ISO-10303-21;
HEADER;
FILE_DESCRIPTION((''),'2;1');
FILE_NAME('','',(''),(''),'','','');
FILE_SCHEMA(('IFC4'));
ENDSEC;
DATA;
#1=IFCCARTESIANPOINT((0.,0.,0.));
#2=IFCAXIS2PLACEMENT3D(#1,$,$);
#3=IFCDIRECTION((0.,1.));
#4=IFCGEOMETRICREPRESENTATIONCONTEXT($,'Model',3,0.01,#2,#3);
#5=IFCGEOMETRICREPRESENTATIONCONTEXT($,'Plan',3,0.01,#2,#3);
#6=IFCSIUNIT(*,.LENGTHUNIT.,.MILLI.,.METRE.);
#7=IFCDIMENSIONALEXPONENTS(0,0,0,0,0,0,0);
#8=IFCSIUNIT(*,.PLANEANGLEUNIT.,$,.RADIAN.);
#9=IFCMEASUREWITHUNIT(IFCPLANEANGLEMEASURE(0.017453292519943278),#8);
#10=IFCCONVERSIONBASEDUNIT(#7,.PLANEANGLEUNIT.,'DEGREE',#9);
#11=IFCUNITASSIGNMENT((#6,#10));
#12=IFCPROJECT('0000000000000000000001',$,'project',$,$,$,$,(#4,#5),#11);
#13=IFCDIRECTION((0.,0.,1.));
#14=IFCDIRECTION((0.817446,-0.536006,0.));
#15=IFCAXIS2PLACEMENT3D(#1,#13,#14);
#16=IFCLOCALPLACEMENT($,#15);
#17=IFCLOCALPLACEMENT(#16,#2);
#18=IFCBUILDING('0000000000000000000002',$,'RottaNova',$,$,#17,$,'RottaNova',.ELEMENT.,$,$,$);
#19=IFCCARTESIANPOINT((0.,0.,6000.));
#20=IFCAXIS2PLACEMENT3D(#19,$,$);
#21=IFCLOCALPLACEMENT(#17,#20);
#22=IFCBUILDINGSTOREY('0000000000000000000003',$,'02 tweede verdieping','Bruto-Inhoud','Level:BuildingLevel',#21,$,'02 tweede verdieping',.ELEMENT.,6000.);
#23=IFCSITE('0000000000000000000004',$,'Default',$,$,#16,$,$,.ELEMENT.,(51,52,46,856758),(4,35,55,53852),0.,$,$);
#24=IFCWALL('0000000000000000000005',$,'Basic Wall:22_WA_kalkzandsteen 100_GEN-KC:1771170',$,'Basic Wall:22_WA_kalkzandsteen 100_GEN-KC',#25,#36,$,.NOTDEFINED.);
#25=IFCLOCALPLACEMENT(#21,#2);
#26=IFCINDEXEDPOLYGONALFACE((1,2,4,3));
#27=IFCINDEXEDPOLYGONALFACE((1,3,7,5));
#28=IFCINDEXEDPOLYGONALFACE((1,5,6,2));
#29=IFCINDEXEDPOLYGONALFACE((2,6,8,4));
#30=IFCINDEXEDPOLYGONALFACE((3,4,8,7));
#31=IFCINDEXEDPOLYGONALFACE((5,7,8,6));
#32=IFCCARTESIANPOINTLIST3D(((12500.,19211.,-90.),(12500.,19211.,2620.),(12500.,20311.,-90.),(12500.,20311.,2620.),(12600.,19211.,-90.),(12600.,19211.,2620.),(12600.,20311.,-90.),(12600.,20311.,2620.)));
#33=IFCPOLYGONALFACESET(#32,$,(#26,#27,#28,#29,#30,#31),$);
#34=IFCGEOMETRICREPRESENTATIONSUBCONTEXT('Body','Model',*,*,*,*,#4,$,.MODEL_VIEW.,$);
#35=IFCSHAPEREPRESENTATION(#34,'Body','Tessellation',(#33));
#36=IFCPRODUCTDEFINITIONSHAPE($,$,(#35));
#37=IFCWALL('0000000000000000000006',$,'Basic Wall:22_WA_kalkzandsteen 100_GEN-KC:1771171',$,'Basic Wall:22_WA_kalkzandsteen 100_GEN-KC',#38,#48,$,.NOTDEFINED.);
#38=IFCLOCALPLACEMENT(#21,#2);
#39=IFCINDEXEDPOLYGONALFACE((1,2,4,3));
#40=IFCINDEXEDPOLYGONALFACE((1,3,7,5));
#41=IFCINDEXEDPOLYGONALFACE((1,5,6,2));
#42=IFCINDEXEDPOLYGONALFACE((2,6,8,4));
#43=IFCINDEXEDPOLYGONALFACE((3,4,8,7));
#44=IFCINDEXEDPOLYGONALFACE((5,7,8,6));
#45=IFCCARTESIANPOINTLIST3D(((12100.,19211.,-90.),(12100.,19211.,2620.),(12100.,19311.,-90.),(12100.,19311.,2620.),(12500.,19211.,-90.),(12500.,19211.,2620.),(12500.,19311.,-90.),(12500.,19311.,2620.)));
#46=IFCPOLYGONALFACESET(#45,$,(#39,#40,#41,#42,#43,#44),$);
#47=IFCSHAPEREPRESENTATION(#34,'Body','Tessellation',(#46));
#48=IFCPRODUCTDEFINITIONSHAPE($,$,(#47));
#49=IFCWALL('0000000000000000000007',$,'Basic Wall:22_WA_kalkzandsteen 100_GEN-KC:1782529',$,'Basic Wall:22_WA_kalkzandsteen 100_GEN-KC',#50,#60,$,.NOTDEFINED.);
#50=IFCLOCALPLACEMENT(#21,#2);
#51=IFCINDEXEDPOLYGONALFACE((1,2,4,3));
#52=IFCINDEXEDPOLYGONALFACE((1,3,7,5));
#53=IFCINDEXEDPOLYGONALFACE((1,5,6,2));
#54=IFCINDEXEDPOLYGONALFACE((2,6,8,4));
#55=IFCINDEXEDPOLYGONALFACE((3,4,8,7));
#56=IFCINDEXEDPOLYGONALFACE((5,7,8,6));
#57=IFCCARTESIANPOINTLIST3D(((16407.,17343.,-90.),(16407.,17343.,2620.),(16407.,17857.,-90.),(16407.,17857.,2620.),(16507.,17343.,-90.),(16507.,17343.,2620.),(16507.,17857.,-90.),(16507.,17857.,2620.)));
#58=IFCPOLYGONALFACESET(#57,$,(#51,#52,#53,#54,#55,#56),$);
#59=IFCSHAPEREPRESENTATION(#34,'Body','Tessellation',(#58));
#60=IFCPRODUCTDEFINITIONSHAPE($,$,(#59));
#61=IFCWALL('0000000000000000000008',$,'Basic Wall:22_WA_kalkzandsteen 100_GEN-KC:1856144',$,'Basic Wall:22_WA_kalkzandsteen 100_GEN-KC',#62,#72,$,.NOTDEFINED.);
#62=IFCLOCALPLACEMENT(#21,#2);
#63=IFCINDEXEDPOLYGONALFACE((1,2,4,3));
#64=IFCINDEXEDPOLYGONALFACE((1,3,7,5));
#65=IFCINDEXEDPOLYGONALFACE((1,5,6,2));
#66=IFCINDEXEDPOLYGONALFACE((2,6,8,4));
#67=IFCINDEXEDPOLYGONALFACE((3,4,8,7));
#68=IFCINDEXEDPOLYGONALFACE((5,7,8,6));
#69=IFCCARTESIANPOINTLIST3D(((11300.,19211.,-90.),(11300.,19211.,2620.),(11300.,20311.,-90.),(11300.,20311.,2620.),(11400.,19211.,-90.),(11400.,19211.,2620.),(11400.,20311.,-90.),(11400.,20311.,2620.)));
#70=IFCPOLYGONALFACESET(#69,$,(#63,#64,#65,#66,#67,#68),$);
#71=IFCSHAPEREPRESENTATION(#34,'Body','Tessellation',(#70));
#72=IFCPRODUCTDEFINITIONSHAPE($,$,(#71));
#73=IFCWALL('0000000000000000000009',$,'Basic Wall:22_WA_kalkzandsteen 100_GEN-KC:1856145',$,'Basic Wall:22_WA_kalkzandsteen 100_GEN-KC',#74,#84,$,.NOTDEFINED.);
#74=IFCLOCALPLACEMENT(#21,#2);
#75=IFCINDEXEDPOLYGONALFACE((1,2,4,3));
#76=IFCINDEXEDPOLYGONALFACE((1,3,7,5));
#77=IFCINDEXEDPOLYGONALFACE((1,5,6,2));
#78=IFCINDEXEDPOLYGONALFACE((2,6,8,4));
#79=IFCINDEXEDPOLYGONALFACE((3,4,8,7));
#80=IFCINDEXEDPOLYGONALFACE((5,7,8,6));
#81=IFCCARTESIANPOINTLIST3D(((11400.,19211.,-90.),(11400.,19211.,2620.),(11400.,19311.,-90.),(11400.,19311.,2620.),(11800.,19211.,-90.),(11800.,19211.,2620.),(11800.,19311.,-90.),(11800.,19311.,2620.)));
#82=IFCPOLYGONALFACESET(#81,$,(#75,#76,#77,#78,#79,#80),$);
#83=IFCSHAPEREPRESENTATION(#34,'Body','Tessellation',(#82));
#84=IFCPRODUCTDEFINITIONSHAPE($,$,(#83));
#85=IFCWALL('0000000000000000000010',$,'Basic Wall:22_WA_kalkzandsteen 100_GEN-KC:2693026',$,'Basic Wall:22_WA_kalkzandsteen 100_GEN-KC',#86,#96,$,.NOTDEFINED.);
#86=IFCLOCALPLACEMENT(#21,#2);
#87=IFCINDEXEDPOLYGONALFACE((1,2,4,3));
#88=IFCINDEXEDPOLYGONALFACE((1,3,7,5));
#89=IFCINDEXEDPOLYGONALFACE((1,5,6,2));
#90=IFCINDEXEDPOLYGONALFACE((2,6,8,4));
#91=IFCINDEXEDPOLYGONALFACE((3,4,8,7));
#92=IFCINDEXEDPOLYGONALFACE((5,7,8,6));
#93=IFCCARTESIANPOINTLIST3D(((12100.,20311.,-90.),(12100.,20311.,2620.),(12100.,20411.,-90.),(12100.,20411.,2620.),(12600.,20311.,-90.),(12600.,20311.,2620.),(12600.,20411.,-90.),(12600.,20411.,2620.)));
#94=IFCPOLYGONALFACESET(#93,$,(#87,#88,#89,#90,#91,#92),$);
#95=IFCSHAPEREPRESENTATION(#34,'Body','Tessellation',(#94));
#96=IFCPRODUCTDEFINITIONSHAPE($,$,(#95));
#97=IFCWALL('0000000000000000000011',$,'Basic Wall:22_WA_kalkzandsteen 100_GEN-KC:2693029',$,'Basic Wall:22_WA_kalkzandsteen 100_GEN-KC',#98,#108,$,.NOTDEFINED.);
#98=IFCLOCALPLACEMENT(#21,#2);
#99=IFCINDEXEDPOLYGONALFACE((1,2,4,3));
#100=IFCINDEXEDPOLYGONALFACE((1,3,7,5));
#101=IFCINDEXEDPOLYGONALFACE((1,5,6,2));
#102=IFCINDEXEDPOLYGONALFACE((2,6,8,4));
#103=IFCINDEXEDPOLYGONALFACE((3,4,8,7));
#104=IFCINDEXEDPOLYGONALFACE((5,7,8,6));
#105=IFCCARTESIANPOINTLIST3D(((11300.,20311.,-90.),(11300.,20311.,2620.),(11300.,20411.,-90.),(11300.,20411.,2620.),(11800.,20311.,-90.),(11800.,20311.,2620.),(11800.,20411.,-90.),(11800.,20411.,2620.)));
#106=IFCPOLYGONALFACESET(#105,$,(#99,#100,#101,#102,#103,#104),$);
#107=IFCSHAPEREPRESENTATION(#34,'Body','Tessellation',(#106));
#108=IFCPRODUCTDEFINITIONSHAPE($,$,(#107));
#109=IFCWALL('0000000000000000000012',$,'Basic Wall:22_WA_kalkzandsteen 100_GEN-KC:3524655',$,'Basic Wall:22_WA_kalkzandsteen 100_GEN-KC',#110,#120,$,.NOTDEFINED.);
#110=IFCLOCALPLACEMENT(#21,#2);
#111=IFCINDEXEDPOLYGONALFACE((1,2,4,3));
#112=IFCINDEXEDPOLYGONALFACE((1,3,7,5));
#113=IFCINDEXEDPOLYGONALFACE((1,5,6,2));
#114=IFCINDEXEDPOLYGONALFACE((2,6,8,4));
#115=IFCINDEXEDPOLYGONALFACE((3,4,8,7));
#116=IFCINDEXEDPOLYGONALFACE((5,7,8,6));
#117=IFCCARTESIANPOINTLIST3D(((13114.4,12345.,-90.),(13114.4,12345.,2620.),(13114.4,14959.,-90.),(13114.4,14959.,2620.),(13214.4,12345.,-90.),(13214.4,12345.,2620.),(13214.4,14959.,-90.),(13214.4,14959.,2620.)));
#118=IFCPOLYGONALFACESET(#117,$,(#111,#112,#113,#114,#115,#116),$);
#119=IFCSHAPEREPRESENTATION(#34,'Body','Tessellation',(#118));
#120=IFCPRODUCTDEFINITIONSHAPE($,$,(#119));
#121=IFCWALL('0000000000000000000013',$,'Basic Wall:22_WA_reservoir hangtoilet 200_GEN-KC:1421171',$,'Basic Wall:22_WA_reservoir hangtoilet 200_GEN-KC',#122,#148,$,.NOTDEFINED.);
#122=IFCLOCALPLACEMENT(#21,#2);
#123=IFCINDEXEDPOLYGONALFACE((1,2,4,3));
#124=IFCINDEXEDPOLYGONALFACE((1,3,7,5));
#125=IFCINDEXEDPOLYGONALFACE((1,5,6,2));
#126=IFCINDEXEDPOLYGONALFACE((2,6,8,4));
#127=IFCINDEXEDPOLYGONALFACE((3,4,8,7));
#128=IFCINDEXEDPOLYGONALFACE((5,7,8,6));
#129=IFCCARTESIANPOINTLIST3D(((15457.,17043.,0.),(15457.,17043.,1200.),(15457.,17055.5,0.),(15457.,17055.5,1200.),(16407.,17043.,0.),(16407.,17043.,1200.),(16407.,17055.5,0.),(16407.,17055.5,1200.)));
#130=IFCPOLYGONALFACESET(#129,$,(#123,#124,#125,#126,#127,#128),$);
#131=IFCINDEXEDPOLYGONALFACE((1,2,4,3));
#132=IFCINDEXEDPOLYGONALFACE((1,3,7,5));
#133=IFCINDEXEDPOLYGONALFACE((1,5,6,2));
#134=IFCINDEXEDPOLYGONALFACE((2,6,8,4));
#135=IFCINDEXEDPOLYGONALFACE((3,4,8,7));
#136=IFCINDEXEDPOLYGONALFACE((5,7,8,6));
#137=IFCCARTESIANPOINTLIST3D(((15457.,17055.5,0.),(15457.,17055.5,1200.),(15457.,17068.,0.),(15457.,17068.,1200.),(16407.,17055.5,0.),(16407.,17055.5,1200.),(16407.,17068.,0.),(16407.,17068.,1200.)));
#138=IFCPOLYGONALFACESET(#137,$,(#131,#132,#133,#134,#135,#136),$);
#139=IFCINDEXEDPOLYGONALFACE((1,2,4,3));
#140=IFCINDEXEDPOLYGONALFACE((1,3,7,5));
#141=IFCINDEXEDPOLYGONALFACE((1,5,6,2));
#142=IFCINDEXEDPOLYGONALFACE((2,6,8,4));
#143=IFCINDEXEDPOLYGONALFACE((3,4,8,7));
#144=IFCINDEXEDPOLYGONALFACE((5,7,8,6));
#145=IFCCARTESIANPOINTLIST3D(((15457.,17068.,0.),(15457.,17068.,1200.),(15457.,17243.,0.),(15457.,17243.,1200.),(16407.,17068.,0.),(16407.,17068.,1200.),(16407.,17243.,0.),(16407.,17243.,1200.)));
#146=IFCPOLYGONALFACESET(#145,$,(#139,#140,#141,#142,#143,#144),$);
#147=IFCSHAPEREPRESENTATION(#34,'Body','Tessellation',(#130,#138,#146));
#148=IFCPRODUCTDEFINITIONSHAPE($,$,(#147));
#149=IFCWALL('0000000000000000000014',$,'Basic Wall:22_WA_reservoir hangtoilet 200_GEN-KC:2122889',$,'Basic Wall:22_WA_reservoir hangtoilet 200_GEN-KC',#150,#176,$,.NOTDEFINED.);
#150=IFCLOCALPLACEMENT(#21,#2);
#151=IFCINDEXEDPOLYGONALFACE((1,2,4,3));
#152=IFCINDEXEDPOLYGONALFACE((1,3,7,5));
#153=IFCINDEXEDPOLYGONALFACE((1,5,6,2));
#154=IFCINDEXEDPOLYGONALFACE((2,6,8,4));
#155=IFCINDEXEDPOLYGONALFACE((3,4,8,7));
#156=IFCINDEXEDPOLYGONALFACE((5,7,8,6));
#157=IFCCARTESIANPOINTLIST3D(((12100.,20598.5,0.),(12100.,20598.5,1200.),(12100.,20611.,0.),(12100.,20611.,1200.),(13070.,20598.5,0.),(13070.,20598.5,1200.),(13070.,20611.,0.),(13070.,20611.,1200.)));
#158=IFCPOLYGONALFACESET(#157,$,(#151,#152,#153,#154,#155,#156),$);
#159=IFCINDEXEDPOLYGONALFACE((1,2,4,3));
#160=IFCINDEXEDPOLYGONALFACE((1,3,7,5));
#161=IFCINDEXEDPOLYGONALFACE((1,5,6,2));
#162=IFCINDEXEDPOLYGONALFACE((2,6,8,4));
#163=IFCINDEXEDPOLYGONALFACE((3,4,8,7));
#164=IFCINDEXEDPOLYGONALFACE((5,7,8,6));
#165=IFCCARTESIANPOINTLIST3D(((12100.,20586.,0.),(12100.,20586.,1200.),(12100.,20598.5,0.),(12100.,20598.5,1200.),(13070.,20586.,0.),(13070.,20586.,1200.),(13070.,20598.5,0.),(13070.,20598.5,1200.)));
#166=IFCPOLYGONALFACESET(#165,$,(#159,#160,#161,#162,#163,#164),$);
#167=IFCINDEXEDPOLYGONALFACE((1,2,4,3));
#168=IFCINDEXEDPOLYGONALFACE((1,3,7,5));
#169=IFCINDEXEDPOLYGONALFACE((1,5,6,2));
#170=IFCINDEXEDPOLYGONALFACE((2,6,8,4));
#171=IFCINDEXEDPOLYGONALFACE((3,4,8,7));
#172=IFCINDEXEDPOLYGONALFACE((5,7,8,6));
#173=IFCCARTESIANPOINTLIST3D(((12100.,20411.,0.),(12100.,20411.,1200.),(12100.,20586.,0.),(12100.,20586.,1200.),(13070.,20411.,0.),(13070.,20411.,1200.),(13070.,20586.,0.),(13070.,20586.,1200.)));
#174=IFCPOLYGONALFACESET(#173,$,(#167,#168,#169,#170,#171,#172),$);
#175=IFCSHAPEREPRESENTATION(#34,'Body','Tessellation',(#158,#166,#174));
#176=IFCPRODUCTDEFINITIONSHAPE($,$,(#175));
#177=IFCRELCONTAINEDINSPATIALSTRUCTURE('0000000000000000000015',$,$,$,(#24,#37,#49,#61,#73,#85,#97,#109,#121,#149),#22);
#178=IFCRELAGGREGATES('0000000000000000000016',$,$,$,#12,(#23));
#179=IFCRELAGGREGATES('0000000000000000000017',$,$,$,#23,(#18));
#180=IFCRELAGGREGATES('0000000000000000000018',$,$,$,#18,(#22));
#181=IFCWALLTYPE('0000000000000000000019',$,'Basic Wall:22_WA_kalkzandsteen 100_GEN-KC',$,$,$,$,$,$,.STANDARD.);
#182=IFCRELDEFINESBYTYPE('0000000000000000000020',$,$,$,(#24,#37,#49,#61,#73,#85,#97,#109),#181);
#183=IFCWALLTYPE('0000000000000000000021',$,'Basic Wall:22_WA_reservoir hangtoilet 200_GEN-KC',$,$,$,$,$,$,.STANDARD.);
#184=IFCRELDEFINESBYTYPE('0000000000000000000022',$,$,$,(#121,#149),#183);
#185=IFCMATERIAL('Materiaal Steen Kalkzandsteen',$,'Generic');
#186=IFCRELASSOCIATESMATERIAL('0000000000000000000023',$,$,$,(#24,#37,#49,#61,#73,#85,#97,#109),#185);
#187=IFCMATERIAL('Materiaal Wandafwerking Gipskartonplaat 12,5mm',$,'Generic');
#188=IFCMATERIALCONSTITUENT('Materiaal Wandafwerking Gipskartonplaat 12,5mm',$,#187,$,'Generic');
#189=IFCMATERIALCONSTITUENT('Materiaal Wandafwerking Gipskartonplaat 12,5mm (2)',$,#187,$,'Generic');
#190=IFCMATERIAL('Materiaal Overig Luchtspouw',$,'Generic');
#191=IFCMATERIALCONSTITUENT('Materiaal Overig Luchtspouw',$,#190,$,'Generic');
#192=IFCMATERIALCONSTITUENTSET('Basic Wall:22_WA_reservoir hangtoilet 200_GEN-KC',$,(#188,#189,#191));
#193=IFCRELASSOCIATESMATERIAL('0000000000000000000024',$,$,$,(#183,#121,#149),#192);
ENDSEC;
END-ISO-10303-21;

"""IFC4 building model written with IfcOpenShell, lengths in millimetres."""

from ifc_helpers import new_model, entity, si_unit, converted_unit, direction, frame, origin, place, context, subcontext, project, spatial, indexed_curve, outline, extrude, material, constituent, constituent_set, type_object, element, save


model = new_model("IFC4")

# Units and contexts
model_context = context("Model", 3, precision=0.01, world=origin(), true_north=direction((0.0, 1.0)))
plan_context = context("Plan", 3, precision=0.01, world=origin(), true_north=direction((0.0, 1.0)))
body_context = subcontext(model_context, "Body", "Model", "MODEL_VIEW")
ifc_project = project(units=[si_unit("LENGTHUNIT", "METRE", prefix="MILLI"), converted_unit("PLANEANGLEUNIT", "DEGREE", entity("IfcPlaneAngleMeasure", 0.017453292519943278), si_unit("PLANEANGLEUNIT", "RADIAN"), dimensions=[0, 0, 0, 0, 0, 0, 0])], contexts=[model_context, plan_context])

# Site, building, storey
site_placement = place(None, frame((0.0, 0.0, 0.0), z_axis=(0.0, 0.0, 1.0), x_axis=(0.817446, -0.536006, 0.0)))
site = spatial("IfcSite", under=ifc_project, at=site_placement, Name="Default", CompositionType="ELEMENT", RefLatitude=(51, 52, 46, 856758), RefLongitude=(4, 35, 55, 53852), RefElevation=0.0)
building_placement = place(site_placement, origin())
building = spatial("IfcBuilding", under=site, at=building_placement, Name="RottaNova", LongName="RottaNova", CompositionType="ELEMENT")
storey_placement = place(building_placement, frame((0.0, 0.0, 6000.0)))
storey = spatial("IfcBuildingStorey", under=building, at=storey_placement, Name="02 tweede verdieping", Description="Bruto-Inhoud", ObjectType="Level:BuildingLevel", LongName="02 tweede verdieping", CompositionType="ELEMENT", Elevation=6000.0)

# Walls
ifc_material_1 = material(Name="Materiaal Steen Kalkzandsteen", Category="Generic")
ifc_material_2 = material(Name="Materiaal Wandafwerking Gipskartonplaat 12,5mm", Category="Generic")
wall_type_1 = type_object("IfcWallType", Name="Basic Wall:22_WA_kalkzandsteen 100_GEN-KC", PredefinedType="STANDARD")
wall_1_placement = place(storey_placement, frame((12550.0, 20311.0, -90.0), z_axis=(0.0, 0.0, 1.0), x_axis=(0.0, -1.0, 0.0)))
element("IfcWall", 1, at=wall_1_placement, inside=storey, type_object=wall_type_1, material=ifc_material_1, Name="Basic Wall:22_WA_kalkzandsteen 100_GEN-KC:1771170", ObjectType="Basic Wall:22_WA_kalkzandsteen 100_GEN-KC", PredefinedType="NOTDEFINED", context=body_context, shape_type="SweptSolid", body=[
    extrude(outline(indexed_curve([(1100.0, 50.0), (0.0, 50.0), (0.0, -50.0), (1100.0, -50.0), (1100.0, 50.0)], self_intersect=False)), origin(), (0.0, 0.0, 1.0), 2710.0),
])
wall_2_placement = place(storey_placement, frame((12500.0, 19261.0, -90.0), z_axis=(0.0, 0.0, 1.0), x_axis=(-1.0, 0.0, 0.0)))
element("IfcWall", 2, at=wall_2_placement, inside=storey, type_object=wall_type_1, material=ifc_material_1, Name="Basic Wall:22_WA_kalkzandsteen 100_GEN-KC:1771171", ObjectType="Basic Wall:22_WA_kalkzandsteen 100_GEN-KC", PredefinedType="NOTDEFINED", context=body_context, shape_type="SweptSolid", body=[
    extrude(outline(indexed_curve([(400.0, 50.0), (0.0, 50.0), (0.0, -50.0), (400.0, -50.0), (400.0, 50.0)], self_intersect=False)), origin(), (0.0, 0.0, 1.0), 2710.0),
])
wall_3_placement = place(storey_placement, frame((16457.0, 17343.0, -90.0), z_axis=(0.0, 0.0, 1.0), x_axis=(0.0, 1.0, 0.0)))
element("IfcWall", 3, at=wall_3_placement, inside=storey, type_object=wall_type_1, material=ifc_material_1, Name="Basic Wall:22_WA_kalkzandsteen 100_GEN-KC:1782529", ObjectType="Basic Wall:22_WA_kalkzandsteen 100_GEN-KC", PredefinedType="NOTDEFINED", context=body_context, shape_type="SweptSolid", body=[
    extrude(outline(indexed_curve([(514.0, 50.0), (0.0, 50.0), (0.0, -50.0), (514.0, -50.0), (514.0, 50.0)], self_intersect=False)), origin(), (0.0, 0.0, 1.0), 2710.0),
])
wall_4_placement = place(storey_placement, frame((11350.0, 20311.0, -90.0), z_axis=(0.0, 0.0, 1.0), x_axis=(0.0, -1.0, 0.0)))
element("IfcWall", 4, at=wall_4_placement, inside=storey, type_object=wall_type_1, material=ifc_material_1, Name="Basic Wall:22_WA_kalkzandsteen 100_GEN-KC:1856144", ObjectType="Basic Wall:22_WA_kalkzandsteen 100_GEN-KC", PredefinedType="NOTDEFINED", context=body_context, shape_type="SweptSolid", body=[
    extrude(outline(indexed_curve([(1100.0, 50.0), (0.0, 50.0), (0.0, -50.0), (1100.0, -50.0), (1100.0, 50.0)], self_intersect=False)), origin(), (0.0, 0.0, 1.0), 2710.0),
])
wall_5_placement = place(storey_placement, frame((11400.0, 19261.0, -90.0)))
element("IfcWall", 5, at=wall_5_placement, inside=storey, type_object=wall_type_1, material=ifc_material_1, Name="Basic Wall:22_WA_kalkzandsteen 100_GEN-KC:1856145", ObjectType="Basic Wall:22_WA_kalkzandsteen 100_GEN-KC", PredefinedType="NOTDEFINED", context=body_context, shape_type="SweptSolid", body=[
    extrude(outline(indexed_curve([(400.0, 50.0), (0.0, 50.0), (0.0, -50.0), (400.0, -50.0), (400.0, 50.0)], self_intersect=False)), origin(), (0.0, 0.0, 1.0), 2710.0),
])
wall_6_placement = place(storey_placement, frame((12600.0, 20361.0, -90.0), z_axis=(0.0, 0.0, 1.0), x_axis=(-1.0, 0.0, 0.0)))
element("IfcWall", 6, at=wall_6_placement, inside=storey, type_object=wall_type_1, material=ifc_material_1, Name="Basic Wall:22_WA_kalkzandsteen 100_GEN-KC:2693026", ObjectType="Basic Wall:22_WA_kalkzandsteen 100_GEN-KC", PredefinedType="NOTDEFINED", context=body_context, shape_type="SweptSolid", body=[
    extrude(outline(indexed_curve([(500.0, 50.0), (0.0, 50.0), (0.0, -50.0), (500.0, -50.0), (500.0, 50.0)], self_intersect=False)), origin(), (0.0, 0.0, 1.0), 2710.0),
])
wall_7_placement = place(storey_placement, frame((11300.0, 20361.0, -90.0)))
element("IfcWall", 7, at=wall_7_placement, inside=storey, type_object=wall_type_1, material=ifc_material_1, Name="Basic Wall:22_WA_kalkzandsteen 100_GEN-KC:2693029", ObjectType="Basic Wall:22_WA_kalkzandsteen 100_GEN-KC", PredefinedType="NOTDEFINED", context=body_context, shape_type="SweptSolid", body=[
    extrude(outline(indexed_curve([(500.0, 50.0), (0.0, 50.0), (0.0, -50.0), (500.0, -50.0), (500.0, 50.0)], self_intersect=False)), origin(), (0.0, 0.0, 1.0), 2710.0),
])
wall_8_placement = place(storey_placement, frame((13164.4, 14959.0, -90.0), z_axis=(0.0, 0.0, 1.0), x_axis=(0.0, -1.0, 0.0)))
element("IfcWall", 8, at=wall_8_placement, inside=storey, type_object=wall_type_1, material=ifc_material_1, Name="Basic Wall:22_WA_kalkzandsteen 100_GEN-KC:3524655", ObjectType="Basic Wall:22_WA_kalkzandsteen 100_GEN-KC", PredefinedType="NOTDEFINED", context=body_context, shape_type="SweptSolid", body=[
    extrude(outline(indexed_curve([(2614.0, 50.0), (0.0, 50.0), (0.0, -50.0), (2614.0, -50.0), (2614.0, 50.0)], self_intersect=False)), origin(), (0.0, 0.0, 1.0), 2710.0),
])
ifc_constituent_1 = constituent(ifc_material_2, Name="Materiaal Wandafwerking Gipskartonplaat 12,5mm", Category="Generic")
ifc_constituent_2 = constituent(ifc_material_2, Name="Materiaal Wandafwerking Gipskartonplaat 12,5mm (2)", Category="Generic")
ifc_material_3 = material(Name="Materiaal Overig Luchtspouw", Category="Generic")
ifc_constituent_3 = constituent(ifc_material_3, Name="Materiaal Overig Luchtspouw", Category="Generic")
ifc_constituent_set_1 = constituent_set(constituents=[ifc_constituent_1, ifc_constituent_2, ifc_constituent_3], Name="Basic Wall:22_WA_reservoir hangtoilet 200_GEN-KC")
wall_type_2 = type_object("IfcWallType", Name="Basic Wall:22_WA_reservoir hangtoilet 200_GEN-KC", PredefinedType="STANDARD", material=ifc_constituent_set_1)
wall_9_placement = place(storey_placement, frame((16407.0, 17143.0, 0.0), z_axis=(0.0, 0.0, 1.0), x_axis=(-1.0, 0.0, 0.0)))
element("IfcWall", 9, at=wall_9_placement, inside=storey, type_object=wall_type_2, material=ifc_constituent_set_1, Name="Basic Wall:22_WA_reservoir hangtoilet 200_GEN-KC:1421171", ObjectType="Basic Wall:22_WA_reservoir hangtoilet 200_GEN-KC", PredefinedType="NOTDEFINED", context=body_context, shape_type="SweptSolid", body=[
    extrude(outline(indexed_curve([(-6.3, -475.0), (6.2, -475.0), (6.3, 475.0), (-6.2, 475.0), (-6.3, -475.0)], self_intersect=False)), frame((475.0, 93.7, 0.0), z_axis=(0.0, 0.0, 1.0), x_axis=(0.0, -1.0, 0.0)), (0.0, 0.0, 1.0), 1200.0),
    extrude(outline(indexed_curve([(-475.0, -6.2), (475.0, -6.2), (475.0, 6.2), (-475.0, 6.2), (-475.0, -6.2)], self_intersect=False)), frame((475.0, 81.2, 0.0)), (0.0, 0.0, 1.0), 1200.0),
    extrude(outline(indexed_curve([(-87.5, -475.0), (87.5, -475.0), (87.5, 475.0), (-87.5, 475.0), (-87.5, -475.0)], self_intersect=False)), frame((475.0, -12.5, 0.0), z_axis=(0.0, 0.0, 1.0), x_axis=(0.0, 1.0, 0.0)), (0.0, 0.0, 1.0), 1200.0),
])
wall_10_placement = place(storey_placement, frame((13070.0, 20511.0, 0.0), z_axis=(0.0, 0.0, 1.0), x_axis=(-1.0, 0.0, 0.0)))
element("IfcWall", 10, at=wall_10_placement, inside=storey, type_object=wall_type_2, material=ifc_constituent_set_1, Name="Basic Wall:22_WA_reservoir hangtoilet 200_GEN-KC:2122889", ObjectType="Basic Wall:22_WA_reservoir hangtoilet 200_GEN-KC", PredefinedType="NOTDEFINED", context=body_context, shape_type="SweptSolid", body=[
    extrude(outline(indexed_curve([(-6.2, -485.0), (6.3, -485.0), (6.2, 485.0), (-6.3, 485.0), (-6.2, -485.0)], self_intersect=False)), frame((485.0, -93.8, 0.0), z_axis=(0.0, 0.0, 1.0), x_axis=(0.0, 1.0, 0.0)), (0.0, 0.0, 1.0), 1200.0),
    extrude(outline(indexed_curve([(-485.0, -6.3), (485.0, -6.3), (485.0, 6.2), (-485.0, 6.2), (-485.0, -6.3)], self_intersect=False)), frame((485.0, -81.2, 0.0)), (0.0, 0.0, 1.0), 1200.0),
    extrude(outline(indexed_curve([(-87.5, -485.0), (87.5, -485.0), (87.5, 485.0), (-87.5, 485.0), (-87.5, -485.0)], self_intersect=False)), frame((485.0, 12.5, 0.0), z_axis=(0.0, 0.0, 1.0), x_axis=(0.0, -1.0, 0.0)), (0.0, 0.0, 1.0), 1200.0),
])

save(model, "model.ifc")
